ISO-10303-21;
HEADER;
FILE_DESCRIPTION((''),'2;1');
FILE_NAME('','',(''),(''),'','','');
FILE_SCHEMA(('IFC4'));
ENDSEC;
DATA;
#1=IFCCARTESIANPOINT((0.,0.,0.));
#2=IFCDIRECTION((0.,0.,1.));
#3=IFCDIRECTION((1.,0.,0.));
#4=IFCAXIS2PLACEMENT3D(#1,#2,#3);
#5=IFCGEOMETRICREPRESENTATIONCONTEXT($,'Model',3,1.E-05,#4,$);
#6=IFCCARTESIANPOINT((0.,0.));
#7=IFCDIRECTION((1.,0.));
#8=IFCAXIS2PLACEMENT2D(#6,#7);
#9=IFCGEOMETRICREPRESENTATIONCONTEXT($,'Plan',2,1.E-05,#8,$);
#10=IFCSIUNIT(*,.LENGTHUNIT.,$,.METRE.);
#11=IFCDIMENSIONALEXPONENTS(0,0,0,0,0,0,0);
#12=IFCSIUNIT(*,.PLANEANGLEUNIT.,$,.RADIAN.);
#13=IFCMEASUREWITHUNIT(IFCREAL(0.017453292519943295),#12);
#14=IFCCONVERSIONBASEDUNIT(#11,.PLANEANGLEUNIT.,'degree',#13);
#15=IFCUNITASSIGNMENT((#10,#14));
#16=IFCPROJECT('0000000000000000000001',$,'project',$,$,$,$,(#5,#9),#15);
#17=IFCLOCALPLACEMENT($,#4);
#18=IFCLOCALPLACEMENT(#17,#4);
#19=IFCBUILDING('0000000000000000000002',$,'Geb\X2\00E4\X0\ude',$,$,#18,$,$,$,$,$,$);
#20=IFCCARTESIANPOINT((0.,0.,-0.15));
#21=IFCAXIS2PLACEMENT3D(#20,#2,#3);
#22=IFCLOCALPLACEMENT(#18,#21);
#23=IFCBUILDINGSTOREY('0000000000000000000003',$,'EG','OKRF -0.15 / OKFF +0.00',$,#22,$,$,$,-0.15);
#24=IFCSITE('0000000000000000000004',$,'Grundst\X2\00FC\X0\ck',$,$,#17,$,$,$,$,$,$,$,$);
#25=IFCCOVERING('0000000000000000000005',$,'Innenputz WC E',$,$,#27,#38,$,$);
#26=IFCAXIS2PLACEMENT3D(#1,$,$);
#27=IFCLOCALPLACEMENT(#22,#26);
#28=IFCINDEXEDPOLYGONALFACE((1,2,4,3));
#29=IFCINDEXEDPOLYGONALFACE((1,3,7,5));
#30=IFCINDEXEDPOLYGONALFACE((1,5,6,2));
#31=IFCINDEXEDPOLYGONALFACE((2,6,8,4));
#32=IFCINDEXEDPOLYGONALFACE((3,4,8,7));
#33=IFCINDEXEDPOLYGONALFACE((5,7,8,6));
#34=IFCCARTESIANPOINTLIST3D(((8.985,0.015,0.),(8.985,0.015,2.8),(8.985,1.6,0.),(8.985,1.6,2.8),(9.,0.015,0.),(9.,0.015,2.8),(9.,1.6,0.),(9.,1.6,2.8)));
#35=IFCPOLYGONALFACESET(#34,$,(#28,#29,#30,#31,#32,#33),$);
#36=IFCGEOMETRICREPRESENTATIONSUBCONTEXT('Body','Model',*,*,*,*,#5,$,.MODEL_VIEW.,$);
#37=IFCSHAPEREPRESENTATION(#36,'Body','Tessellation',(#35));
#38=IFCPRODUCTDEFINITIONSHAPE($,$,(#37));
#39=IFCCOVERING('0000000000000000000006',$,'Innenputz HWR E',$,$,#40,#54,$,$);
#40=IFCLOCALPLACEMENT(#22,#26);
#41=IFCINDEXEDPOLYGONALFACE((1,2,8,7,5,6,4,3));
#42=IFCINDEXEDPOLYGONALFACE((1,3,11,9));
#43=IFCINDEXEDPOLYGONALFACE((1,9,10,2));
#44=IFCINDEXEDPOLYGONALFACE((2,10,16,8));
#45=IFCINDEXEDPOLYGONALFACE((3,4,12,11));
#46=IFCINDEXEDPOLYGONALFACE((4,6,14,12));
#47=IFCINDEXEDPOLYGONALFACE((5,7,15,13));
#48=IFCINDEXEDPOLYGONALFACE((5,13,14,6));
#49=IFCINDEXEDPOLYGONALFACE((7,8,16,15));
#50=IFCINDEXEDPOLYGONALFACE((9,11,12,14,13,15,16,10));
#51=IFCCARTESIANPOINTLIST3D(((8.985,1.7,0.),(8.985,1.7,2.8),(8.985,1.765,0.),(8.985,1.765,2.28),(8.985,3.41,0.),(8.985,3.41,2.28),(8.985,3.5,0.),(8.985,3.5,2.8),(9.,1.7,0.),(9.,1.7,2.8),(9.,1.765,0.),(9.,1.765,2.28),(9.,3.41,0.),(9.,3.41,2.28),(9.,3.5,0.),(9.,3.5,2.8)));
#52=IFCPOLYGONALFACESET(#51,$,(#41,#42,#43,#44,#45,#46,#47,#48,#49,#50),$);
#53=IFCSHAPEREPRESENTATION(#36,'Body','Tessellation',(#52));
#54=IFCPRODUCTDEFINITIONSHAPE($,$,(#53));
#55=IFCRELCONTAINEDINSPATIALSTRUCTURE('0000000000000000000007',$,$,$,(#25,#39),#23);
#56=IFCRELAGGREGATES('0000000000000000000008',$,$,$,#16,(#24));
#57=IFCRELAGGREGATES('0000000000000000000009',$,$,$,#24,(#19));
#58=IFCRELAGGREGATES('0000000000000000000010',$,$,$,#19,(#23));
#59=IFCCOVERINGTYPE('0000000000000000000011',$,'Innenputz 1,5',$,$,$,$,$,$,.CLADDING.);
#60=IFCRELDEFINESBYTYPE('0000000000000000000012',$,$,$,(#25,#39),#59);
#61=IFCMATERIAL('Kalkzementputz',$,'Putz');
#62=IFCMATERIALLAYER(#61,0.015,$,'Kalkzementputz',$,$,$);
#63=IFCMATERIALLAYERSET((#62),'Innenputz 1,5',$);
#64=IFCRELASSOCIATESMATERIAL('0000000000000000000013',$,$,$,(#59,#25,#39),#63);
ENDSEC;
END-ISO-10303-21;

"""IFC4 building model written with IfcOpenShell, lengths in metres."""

from ifc_helpers import new_model, entity, si_unit, converted_unit, frame, origin_with_axes, origin_2d_with_axis, place, context, subcontext, project, spatial, indexed_curve, outline, extrude, material, layer, layer_set, layer_usage, type_object, element, save


model = new_model("IFC4")

# Units and contexts
model_context = context("Model", 3, precision=1e-05, world=origin_with_axes())
plan_context = context("Plan", 2, precision=1e-05, world=origin_2d_with_axis())
body_context = subcontext(model_context, "Body", "Model", "MODEL_VIEW")
ifc_project = project(units=[si_unit("LENGTHUNIT", "METRE"), converted_unit("PLANEANGLEUNIT", "degree", entity("IfcReal", 0.017453292519943295), si_unit("PLANEANGLEUNIT", "RADIAN"), dimensions=[0, 0, 0, 0, 0, 0, 0])], contexts=[model_context, plan_context])

# Site, building, storey
site_placement = place(None, origin_with_axes())
site = spatial("IfcSite", under=ifc_project, at=site_placement, Name="Grundstück")
building_placement = place(site_placement, origin_with_axes())
building = spatial("IfcBuilding", under=site, at=building_placement, Name="Gebäude")
storey_placement = place(building_placement, frame((0.0, 0.0, -0.15), z_axis=(0.0, 0.0, 1.0), x_axis=(1.0, 0.0, 0.0)))
storey = spatial("IfcBuildingStorey", under=building, at=storey_placement, Name="EG", Description="OKRF -0.15 / OKFF +0.00", Elevation=-0.15)

# Covering
ifc_material_1 = material(Name="Kalkzementputz", Category="Putz")
ifc_layer_1 = layer(ifc_material_1, 0.015, Name="Kalkzementputz")
ifc_layer_set_1 = layer_set([ifc_layer_1], Name="Innenputz 1,5")
ifc_layer_usage_1 = layer_usage(ifc_layer_set_1, "AXIS2", "POSITIVE", 0.0)
covering_type_1 = type_object("IfcCoveringType", Name="Innenputz 1,5", PredefinedType="CLADDING", material=ifc_layer_set_1)
covering_1_placement = place(storey_placement, frame((9.0, 0.015, 0.0), z_axis=(0.0, 0.0, 1.0), x_axis=(0.0, 1.0, 0.0)))
element("IfcCovering", 1, at=covering_1_placement, inside=storey, type_object=covering_type_1, material=ifc_layer_usage_1, Name="Innenputz WC E", context=body_context, shape_type="SweptSolid", body=[
    extrude(outline(indexed_curve([(0.0, 0.0), (0.0, 0.015), (1.585, 0.015), (1.585, 0.0), (0.0, 0.0)], self_intersect=False)), origin_with_axes(), (0.0, 0.0, 1.0), 2.8),
])

# Covering, opening
ifc_layer_usage_2 = layer_usage(ifc_layer_set_1, "AXIS2", "POSITIVE", 0.0)
covering_2_placement = place(storey_placement, frame((9.0, 1.7, 0.0), z_axis=(0.0, 0.0, 1.0), x_axis=(0.0, 1.0, 0.0)))
covering_2 = element("IfcCovering", 2, at=covering_2_placement, inside=storey, type_object=covering_type_1, material=ifc_layer_usage_2, Name="Innenputz HWR E", context=body_context, shape_type="SweptSolid", body=[
    extrude(outline(indexed_curve([(0.0, 0.0), (0.0, 0.015), (1.8, 0.015), (1.8, 0.0), (0.0, 0.0)], self_intersect=False)), origin_with_axes(), (0.0, 0.0, 1.0), 2.8),
])
opening_1_placement = place(covering_2_placement, frame((0.065, -0.05, 0.0), z_axis=(0.0, 0.0, 1.0), x_axis=(1.0, 0.0, 0.0)))
element("IfcOpeningElement", 3, at=opening_1_placement, cuts=covering_2, context=body_context, shape_type="SweptSolid", body=[
    extrude(outline(indexed_curve([(0.0, 0.0), (0.0, 0.115), (1.645, 0.115), (1.645, 0.0), (0.0, 0.0)], self_intersect=False)), origin_with_axes(), (0.0, 0.0, 1.0), 2.28),
])

save(model, "model.ifc")
